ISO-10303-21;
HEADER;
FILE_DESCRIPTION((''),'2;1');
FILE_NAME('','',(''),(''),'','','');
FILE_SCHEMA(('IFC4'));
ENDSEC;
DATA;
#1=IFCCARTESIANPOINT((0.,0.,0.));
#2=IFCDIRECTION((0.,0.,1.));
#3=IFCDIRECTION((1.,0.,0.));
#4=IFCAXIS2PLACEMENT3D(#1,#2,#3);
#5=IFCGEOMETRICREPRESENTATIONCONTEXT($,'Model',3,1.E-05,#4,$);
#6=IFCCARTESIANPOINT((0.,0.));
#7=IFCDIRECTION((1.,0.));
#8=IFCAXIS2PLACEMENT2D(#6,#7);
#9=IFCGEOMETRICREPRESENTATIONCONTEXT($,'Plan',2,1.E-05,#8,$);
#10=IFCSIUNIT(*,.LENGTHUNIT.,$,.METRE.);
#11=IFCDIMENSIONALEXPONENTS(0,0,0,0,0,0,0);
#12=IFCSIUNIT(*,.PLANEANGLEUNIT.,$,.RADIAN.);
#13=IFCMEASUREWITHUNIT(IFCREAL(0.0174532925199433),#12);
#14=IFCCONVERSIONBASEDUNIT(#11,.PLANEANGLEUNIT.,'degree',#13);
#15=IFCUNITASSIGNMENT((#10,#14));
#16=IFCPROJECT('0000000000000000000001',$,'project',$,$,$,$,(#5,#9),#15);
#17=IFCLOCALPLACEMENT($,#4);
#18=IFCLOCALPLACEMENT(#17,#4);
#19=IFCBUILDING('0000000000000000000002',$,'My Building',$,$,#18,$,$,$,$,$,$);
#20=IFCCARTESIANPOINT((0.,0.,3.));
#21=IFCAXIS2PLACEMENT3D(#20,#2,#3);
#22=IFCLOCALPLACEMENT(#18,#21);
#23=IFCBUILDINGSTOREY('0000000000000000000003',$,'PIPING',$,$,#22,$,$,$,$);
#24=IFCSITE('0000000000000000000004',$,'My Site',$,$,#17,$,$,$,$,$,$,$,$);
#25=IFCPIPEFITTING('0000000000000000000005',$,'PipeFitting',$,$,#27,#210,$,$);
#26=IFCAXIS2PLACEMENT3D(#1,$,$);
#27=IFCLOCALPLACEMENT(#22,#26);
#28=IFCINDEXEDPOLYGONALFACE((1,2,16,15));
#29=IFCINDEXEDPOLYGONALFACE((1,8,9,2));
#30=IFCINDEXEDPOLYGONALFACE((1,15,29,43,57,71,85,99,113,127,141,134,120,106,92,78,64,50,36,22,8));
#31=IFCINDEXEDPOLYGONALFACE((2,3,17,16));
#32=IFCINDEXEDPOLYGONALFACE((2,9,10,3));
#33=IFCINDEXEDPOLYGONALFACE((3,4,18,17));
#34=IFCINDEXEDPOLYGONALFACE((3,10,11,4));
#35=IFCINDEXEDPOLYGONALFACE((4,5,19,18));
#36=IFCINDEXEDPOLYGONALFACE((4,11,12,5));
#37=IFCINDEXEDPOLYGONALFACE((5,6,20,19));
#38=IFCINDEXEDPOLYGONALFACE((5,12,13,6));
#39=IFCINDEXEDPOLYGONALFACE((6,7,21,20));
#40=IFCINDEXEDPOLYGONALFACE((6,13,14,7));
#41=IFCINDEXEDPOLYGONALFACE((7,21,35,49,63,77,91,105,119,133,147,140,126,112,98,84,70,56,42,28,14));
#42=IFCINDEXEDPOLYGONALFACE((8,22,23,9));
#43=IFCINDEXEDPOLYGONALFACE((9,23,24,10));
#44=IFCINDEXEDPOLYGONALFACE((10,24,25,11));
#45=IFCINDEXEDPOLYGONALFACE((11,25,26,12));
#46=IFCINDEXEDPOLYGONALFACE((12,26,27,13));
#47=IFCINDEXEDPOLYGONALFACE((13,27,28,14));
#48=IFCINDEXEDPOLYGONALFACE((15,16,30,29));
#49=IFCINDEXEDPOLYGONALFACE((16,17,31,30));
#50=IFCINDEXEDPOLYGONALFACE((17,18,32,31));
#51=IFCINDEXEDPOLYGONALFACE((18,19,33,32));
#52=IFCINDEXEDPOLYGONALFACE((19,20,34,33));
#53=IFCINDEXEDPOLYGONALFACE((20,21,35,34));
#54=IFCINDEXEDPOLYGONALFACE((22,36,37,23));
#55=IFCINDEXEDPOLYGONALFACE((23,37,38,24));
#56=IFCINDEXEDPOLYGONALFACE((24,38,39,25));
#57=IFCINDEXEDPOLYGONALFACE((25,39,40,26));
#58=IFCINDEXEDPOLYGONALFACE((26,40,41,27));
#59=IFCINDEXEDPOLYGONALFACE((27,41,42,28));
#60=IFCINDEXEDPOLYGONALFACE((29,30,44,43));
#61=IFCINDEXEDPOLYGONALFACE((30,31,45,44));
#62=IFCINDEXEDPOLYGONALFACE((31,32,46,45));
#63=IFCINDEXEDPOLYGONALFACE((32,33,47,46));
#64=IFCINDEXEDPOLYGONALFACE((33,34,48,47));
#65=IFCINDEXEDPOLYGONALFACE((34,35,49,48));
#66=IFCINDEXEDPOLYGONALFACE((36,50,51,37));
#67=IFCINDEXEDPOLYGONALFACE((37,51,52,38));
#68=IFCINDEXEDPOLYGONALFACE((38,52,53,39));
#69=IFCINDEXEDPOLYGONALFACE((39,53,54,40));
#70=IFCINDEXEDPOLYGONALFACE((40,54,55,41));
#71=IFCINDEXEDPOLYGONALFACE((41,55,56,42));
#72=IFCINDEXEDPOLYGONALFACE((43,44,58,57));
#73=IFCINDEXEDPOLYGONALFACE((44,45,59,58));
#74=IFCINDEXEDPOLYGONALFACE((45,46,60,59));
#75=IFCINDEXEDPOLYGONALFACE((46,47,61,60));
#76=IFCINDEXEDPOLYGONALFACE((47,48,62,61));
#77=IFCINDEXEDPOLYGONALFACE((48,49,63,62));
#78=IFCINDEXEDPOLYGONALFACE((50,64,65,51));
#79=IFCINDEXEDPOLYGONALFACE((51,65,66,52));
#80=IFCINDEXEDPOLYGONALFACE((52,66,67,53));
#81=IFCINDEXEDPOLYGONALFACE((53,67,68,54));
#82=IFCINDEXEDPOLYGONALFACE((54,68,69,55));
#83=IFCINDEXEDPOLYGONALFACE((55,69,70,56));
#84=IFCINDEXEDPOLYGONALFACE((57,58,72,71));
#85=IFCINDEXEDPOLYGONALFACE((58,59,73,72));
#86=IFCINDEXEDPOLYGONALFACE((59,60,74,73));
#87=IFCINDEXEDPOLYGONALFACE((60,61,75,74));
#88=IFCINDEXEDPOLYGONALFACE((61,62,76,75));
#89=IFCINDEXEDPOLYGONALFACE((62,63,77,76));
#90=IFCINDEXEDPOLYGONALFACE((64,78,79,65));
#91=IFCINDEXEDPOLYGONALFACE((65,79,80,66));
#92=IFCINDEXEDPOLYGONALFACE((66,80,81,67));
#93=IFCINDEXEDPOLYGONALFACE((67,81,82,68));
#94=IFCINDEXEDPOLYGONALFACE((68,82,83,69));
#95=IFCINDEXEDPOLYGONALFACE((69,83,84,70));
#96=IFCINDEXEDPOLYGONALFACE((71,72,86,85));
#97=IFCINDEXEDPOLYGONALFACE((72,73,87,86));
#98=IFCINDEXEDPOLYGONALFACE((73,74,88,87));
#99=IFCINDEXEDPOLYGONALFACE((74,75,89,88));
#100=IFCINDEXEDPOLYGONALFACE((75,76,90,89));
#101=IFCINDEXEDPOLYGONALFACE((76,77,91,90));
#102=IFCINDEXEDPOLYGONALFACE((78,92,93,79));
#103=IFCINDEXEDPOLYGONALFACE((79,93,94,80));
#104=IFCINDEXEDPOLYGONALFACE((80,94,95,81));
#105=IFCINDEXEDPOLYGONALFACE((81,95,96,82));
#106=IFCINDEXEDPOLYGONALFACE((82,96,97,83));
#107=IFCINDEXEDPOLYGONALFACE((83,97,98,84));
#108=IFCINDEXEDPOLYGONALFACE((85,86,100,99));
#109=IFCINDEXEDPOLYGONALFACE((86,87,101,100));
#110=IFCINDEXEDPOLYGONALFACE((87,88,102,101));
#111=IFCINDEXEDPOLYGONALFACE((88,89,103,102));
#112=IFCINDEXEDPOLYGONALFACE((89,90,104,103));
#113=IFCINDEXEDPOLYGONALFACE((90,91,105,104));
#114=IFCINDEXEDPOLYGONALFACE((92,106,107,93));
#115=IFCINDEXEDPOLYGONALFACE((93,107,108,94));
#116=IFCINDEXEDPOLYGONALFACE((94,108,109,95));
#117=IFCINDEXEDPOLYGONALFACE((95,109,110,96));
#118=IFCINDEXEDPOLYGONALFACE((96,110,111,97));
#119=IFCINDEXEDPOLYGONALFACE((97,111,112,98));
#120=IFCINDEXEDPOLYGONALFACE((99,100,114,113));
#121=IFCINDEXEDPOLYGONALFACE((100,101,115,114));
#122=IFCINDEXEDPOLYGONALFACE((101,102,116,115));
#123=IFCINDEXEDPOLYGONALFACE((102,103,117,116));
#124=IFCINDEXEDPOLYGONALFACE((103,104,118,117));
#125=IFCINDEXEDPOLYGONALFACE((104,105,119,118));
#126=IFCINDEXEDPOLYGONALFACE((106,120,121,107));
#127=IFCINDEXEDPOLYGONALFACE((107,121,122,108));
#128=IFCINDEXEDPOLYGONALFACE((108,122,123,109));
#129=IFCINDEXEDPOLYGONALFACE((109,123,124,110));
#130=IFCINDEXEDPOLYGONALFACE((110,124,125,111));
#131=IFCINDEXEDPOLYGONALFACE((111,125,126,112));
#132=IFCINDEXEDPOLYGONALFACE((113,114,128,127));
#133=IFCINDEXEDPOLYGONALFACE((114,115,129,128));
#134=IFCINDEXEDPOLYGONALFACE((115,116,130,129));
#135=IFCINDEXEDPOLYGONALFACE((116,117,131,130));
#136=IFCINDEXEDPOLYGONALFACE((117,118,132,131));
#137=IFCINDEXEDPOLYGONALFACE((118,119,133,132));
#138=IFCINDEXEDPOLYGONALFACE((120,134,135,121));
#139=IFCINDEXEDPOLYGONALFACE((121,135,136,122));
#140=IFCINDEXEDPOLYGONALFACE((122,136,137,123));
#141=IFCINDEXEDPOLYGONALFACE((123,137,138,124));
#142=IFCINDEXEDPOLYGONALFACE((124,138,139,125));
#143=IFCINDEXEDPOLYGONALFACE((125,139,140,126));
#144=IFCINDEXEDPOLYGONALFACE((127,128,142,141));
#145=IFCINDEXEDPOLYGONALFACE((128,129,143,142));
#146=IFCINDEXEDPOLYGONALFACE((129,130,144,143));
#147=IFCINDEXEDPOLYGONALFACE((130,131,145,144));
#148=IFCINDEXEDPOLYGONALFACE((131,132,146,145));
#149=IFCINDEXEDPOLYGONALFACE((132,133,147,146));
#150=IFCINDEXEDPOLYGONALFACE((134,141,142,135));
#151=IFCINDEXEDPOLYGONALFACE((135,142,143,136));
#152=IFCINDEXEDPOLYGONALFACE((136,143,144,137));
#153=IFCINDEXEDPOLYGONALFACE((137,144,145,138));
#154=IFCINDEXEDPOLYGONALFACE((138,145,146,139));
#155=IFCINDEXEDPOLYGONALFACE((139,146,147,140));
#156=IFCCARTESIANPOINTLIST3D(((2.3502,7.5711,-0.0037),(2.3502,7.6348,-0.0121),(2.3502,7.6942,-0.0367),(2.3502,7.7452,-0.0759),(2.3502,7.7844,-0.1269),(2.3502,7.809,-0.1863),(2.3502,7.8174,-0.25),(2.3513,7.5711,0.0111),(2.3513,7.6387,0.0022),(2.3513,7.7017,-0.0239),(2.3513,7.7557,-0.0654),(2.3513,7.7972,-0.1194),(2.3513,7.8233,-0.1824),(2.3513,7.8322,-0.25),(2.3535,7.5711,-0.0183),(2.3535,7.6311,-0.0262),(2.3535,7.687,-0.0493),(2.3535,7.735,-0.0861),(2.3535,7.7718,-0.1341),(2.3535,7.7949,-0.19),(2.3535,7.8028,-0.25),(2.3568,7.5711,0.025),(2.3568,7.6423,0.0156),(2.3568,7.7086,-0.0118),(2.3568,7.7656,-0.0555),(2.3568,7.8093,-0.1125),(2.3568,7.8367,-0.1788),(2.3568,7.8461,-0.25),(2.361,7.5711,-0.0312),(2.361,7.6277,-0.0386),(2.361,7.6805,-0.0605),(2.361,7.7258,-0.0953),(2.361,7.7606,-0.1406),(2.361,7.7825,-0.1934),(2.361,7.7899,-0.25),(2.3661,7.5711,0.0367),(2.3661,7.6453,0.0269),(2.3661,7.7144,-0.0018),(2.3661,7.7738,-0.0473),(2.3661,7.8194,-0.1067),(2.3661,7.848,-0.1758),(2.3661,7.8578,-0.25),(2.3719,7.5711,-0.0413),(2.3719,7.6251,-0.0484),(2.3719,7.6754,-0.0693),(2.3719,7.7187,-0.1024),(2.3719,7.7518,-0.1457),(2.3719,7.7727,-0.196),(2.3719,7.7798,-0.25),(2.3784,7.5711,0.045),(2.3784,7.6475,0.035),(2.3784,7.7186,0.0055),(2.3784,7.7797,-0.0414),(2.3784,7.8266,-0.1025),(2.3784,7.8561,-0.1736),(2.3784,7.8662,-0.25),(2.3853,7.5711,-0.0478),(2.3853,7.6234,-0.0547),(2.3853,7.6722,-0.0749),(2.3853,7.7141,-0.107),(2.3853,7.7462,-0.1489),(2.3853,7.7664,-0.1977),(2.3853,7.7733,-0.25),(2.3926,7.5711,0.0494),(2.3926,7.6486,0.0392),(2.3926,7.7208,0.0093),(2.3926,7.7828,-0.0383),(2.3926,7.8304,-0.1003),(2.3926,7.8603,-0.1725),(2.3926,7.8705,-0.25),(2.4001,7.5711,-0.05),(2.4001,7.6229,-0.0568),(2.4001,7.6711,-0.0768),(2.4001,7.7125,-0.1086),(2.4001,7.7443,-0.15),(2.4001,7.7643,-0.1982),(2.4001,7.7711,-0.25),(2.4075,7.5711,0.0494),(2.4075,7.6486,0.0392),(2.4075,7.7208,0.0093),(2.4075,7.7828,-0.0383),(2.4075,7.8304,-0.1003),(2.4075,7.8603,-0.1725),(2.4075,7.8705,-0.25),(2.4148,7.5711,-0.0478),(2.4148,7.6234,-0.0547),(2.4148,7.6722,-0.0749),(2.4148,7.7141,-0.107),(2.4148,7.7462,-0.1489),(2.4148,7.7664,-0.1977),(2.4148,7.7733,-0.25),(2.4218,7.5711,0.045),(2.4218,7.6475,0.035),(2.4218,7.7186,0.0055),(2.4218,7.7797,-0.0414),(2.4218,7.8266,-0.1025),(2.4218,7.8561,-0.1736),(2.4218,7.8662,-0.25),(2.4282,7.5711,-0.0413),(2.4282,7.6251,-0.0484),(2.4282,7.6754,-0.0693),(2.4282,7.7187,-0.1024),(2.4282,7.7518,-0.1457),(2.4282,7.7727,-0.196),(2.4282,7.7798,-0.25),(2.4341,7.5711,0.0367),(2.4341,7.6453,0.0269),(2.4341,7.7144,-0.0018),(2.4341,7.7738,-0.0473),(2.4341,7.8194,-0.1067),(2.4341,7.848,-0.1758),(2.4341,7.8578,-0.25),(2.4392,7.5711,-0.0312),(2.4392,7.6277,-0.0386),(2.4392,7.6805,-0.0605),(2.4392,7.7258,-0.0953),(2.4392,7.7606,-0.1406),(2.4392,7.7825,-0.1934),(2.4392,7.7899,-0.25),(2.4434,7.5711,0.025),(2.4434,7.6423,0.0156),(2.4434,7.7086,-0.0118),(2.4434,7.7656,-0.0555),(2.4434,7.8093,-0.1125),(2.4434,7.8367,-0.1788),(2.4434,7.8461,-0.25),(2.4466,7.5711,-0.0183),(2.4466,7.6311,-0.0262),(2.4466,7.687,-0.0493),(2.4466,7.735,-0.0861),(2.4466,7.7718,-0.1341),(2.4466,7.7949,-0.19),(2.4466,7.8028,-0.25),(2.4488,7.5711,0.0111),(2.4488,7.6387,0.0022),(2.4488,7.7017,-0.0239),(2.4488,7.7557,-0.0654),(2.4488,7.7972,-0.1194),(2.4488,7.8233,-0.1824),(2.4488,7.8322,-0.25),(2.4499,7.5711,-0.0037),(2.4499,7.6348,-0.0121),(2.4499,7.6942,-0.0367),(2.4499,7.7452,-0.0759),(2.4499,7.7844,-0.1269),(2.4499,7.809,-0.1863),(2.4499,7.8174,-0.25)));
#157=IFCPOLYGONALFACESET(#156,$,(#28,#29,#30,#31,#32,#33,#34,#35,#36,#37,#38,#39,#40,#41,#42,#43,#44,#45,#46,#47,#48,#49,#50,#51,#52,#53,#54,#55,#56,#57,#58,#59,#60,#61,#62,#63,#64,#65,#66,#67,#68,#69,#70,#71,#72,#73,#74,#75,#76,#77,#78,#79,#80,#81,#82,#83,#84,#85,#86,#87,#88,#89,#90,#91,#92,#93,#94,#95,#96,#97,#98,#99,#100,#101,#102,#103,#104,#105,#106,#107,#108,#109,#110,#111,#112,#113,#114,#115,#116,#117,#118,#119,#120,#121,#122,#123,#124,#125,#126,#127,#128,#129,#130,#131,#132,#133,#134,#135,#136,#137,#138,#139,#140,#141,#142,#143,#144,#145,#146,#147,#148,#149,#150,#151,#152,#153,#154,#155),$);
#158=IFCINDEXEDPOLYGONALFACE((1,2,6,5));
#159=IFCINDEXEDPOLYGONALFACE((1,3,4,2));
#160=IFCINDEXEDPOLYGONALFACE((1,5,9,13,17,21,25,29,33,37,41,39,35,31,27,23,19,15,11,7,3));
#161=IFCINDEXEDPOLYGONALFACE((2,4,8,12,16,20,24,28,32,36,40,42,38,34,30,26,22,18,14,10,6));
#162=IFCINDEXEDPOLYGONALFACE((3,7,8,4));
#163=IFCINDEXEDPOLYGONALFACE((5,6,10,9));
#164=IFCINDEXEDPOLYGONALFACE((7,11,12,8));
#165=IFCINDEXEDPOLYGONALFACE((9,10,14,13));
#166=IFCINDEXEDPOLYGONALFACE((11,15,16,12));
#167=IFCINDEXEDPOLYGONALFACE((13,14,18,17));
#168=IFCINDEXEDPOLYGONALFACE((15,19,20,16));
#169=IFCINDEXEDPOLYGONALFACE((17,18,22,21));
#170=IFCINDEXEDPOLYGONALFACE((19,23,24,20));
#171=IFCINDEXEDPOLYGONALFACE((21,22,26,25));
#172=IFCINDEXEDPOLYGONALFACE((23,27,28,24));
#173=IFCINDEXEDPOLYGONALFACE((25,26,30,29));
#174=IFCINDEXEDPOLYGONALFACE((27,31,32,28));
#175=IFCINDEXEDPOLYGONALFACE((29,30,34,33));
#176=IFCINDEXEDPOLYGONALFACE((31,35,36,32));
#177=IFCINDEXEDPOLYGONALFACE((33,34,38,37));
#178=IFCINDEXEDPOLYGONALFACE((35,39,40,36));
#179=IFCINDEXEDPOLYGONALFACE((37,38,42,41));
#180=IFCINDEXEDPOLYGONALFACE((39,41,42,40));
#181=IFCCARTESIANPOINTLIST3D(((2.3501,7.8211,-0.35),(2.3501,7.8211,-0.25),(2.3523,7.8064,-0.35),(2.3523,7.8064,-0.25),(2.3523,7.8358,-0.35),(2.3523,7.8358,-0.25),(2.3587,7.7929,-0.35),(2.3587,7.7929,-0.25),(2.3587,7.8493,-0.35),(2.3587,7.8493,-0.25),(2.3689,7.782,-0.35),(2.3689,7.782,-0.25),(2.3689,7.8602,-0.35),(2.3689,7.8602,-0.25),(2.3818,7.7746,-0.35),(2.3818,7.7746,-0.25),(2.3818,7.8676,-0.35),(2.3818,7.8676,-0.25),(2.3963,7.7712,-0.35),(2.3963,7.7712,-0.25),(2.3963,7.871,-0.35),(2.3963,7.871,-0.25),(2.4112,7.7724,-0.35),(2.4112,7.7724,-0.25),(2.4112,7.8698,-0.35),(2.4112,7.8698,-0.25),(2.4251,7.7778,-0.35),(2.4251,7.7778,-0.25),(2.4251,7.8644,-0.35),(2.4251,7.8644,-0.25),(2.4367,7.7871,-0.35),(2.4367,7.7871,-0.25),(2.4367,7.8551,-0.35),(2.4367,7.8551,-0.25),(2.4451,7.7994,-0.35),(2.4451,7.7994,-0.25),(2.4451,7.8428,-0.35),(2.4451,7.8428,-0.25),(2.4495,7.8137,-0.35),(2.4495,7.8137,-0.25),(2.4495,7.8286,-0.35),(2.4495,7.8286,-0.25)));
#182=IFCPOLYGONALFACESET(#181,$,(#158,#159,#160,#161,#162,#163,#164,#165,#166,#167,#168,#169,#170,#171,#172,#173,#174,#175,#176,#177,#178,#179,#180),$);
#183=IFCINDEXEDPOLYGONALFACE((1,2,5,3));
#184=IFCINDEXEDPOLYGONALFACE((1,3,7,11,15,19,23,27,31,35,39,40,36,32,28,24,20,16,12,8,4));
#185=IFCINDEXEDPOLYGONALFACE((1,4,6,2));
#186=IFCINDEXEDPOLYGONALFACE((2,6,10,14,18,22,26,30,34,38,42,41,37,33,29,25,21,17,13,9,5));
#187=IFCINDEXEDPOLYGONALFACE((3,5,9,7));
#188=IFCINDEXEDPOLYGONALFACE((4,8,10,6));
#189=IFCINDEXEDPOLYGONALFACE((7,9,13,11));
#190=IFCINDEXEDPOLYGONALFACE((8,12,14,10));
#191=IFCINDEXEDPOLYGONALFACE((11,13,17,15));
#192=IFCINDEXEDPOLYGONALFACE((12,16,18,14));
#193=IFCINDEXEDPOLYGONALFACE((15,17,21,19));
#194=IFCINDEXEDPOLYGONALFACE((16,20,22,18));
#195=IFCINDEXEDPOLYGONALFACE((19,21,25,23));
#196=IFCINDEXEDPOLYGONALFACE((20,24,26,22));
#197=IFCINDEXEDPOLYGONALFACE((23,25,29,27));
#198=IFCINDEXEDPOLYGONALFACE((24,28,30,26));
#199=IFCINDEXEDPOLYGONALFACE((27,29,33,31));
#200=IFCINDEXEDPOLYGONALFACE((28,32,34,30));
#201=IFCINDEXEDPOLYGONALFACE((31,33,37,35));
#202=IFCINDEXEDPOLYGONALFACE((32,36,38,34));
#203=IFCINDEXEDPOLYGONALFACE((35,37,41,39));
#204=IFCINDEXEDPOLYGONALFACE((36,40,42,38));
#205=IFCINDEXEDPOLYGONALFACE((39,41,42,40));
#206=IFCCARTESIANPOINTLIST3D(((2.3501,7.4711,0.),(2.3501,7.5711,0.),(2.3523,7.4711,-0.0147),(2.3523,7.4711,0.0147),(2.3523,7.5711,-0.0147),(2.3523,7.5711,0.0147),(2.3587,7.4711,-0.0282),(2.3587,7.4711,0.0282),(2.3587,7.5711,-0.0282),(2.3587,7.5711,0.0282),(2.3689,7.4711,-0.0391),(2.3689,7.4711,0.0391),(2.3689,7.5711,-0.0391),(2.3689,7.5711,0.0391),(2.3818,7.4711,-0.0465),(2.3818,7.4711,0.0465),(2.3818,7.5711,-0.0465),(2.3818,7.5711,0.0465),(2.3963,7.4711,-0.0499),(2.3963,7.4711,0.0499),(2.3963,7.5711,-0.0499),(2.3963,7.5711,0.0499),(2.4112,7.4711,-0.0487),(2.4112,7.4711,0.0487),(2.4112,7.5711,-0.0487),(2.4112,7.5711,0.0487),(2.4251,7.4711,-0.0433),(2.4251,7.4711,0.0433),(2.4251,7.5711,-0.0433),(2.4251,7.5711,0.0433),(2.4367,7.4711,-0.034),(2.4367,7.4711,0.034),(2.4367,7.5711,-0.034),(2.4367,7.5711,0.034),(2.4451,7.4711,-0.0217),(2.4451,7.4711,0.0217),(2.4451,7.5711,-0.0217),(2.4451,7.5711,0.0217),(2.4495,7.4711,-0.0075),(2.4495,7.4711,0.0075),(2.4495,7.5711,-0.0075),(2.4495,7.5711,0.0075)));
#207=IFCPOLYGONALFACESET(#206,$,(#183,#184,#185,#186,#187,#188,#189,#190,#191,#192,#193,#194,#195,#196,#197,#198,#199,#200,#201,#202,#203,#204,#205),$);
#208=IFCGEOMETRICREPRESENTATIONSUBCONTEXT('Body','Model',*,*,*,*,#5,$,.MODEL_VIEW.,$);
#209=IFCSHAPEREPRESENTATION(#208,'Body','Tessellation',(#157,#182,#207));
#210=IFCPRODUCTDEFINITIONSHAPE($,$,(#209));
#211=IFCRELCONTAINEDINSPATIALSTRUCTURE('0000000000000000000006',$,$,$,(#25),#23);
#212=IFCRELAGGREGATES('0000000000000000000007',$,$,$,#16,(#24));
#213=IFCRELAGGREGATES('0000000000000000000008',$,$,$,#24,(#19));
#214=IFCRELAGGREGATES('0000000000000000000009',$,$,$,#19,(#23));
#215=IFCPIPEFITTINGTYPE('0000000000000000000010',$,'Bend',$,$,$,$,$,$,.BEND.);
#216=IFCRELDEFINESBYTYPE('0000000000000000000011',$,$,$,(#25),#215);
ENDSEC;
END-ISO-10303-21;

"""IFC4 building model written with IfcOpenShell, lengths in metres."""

from ifc_helpers import new_model, entity, si_unit, converted_unit, frame, origin_with_axes, origin_2d_with_axis, place, context, subcontext, project, spatial, circle, extrude, source, transform, mapped, type_object, type_shapes, element, save


model = new_model("IFC4")

# Units and contexts
model_context = context("Model", 3, precision=1e-05, world=origin_with_axes())
plan_context = context("Plan", 2, precision=1e-05, world=origin_2d_with_axis())
body_context = subcontext(model_context, "Body", "Model", "MODEL_VIEW")
ifc_project = project(units=[si_unit("LENGTHUNIT", "METRE"), converted_unit("PLANEANGLEUNIT", "degree", entity("IfcReal", 0.0174532925199433), si_unit("PLANEANGLEUNIT", "RADIAN"), dimensions=[0, 0, 0, 0, 0, 0, 0])], contexts=[model_context, plan_context])

# Site, building, storey
site_placement = place(None, origin_with_axes())
site = spatial("IfcSite", under=ifc_project, at=site_placement, Name="My Site")
building_placement = place(site_placement, origin_with_axes())
building = spatial("IfcBuilding", under=site, at=building_placement, Name="My Building")
storey_placement = place(building_placement, frame((0.0, 0.0, 3.0), z_axis=(0.0, 0.0, 1.0), x_axis=(1.0, 0.0, 0.0)))
storey = spatial("IfcBuildingStorey", under=building, at=storey_placement, Name="PIPING")

# Pipe fitting
pipe_fitting_type_1 = type_object("IfcPipeFittingType", Name="Bend", PredefinedType="BEND")
shared_shape = source(origin_with_axes(), body_context, "Body", "SolidModel", [
    entity("IfcSweptDiskSolid", entity("IfcIndexedPolyCurve", entity("IfcCartesianPointList3D", [[0.0, 0.0, -0.1], [0.0, -0.0732, -0.2768], [0.0, -0.25, -0.35]]), [entity("IfcArcIndex", [1, 2, 3])]), 0.05),
    extrude(circle(Radius=0.05), origin_with_axes(), (0.0, 0.0, -1.0), 0.1),
    extrude(circle(Radius=0.05), frame((0.0, -0.25, -0.35), z_axis=(0.0, -1.0, 0.0), x_axis=(1.0, 0.0, 0.0)), (0.0, 0.0, 1.0), 0.1),
])
type_shapes(pipe_fitting_type_1, [shared_shape])
for number, where, z_axis, x_axis, name in (
    (1, (2.4001, 7.8211, -0.35), (0.0, 0.0, -1.0), (-1.0, 0.0, 0.0), "PipeFitting"),
):
    element("IfcPipeFitting", number, at=place(storey_placement, frame(where, z_axis=z_axis, x_axis=x_axis)), inside=storey, type_object=pipe_fitting_type_1, Name=name, context=body_context, shape_type="MappedRepresentation", body=[
        mapped(shared_shape, transform((0.0, 0.0, 0.0), x_axis=(1.0, 0.0, 0.0), y_axis=(0.0, 1.0, 0.0), z_axis=(0.0, 0.0, 1.0), scale=1.0)),
    ])

save(model, "model.ifc")
